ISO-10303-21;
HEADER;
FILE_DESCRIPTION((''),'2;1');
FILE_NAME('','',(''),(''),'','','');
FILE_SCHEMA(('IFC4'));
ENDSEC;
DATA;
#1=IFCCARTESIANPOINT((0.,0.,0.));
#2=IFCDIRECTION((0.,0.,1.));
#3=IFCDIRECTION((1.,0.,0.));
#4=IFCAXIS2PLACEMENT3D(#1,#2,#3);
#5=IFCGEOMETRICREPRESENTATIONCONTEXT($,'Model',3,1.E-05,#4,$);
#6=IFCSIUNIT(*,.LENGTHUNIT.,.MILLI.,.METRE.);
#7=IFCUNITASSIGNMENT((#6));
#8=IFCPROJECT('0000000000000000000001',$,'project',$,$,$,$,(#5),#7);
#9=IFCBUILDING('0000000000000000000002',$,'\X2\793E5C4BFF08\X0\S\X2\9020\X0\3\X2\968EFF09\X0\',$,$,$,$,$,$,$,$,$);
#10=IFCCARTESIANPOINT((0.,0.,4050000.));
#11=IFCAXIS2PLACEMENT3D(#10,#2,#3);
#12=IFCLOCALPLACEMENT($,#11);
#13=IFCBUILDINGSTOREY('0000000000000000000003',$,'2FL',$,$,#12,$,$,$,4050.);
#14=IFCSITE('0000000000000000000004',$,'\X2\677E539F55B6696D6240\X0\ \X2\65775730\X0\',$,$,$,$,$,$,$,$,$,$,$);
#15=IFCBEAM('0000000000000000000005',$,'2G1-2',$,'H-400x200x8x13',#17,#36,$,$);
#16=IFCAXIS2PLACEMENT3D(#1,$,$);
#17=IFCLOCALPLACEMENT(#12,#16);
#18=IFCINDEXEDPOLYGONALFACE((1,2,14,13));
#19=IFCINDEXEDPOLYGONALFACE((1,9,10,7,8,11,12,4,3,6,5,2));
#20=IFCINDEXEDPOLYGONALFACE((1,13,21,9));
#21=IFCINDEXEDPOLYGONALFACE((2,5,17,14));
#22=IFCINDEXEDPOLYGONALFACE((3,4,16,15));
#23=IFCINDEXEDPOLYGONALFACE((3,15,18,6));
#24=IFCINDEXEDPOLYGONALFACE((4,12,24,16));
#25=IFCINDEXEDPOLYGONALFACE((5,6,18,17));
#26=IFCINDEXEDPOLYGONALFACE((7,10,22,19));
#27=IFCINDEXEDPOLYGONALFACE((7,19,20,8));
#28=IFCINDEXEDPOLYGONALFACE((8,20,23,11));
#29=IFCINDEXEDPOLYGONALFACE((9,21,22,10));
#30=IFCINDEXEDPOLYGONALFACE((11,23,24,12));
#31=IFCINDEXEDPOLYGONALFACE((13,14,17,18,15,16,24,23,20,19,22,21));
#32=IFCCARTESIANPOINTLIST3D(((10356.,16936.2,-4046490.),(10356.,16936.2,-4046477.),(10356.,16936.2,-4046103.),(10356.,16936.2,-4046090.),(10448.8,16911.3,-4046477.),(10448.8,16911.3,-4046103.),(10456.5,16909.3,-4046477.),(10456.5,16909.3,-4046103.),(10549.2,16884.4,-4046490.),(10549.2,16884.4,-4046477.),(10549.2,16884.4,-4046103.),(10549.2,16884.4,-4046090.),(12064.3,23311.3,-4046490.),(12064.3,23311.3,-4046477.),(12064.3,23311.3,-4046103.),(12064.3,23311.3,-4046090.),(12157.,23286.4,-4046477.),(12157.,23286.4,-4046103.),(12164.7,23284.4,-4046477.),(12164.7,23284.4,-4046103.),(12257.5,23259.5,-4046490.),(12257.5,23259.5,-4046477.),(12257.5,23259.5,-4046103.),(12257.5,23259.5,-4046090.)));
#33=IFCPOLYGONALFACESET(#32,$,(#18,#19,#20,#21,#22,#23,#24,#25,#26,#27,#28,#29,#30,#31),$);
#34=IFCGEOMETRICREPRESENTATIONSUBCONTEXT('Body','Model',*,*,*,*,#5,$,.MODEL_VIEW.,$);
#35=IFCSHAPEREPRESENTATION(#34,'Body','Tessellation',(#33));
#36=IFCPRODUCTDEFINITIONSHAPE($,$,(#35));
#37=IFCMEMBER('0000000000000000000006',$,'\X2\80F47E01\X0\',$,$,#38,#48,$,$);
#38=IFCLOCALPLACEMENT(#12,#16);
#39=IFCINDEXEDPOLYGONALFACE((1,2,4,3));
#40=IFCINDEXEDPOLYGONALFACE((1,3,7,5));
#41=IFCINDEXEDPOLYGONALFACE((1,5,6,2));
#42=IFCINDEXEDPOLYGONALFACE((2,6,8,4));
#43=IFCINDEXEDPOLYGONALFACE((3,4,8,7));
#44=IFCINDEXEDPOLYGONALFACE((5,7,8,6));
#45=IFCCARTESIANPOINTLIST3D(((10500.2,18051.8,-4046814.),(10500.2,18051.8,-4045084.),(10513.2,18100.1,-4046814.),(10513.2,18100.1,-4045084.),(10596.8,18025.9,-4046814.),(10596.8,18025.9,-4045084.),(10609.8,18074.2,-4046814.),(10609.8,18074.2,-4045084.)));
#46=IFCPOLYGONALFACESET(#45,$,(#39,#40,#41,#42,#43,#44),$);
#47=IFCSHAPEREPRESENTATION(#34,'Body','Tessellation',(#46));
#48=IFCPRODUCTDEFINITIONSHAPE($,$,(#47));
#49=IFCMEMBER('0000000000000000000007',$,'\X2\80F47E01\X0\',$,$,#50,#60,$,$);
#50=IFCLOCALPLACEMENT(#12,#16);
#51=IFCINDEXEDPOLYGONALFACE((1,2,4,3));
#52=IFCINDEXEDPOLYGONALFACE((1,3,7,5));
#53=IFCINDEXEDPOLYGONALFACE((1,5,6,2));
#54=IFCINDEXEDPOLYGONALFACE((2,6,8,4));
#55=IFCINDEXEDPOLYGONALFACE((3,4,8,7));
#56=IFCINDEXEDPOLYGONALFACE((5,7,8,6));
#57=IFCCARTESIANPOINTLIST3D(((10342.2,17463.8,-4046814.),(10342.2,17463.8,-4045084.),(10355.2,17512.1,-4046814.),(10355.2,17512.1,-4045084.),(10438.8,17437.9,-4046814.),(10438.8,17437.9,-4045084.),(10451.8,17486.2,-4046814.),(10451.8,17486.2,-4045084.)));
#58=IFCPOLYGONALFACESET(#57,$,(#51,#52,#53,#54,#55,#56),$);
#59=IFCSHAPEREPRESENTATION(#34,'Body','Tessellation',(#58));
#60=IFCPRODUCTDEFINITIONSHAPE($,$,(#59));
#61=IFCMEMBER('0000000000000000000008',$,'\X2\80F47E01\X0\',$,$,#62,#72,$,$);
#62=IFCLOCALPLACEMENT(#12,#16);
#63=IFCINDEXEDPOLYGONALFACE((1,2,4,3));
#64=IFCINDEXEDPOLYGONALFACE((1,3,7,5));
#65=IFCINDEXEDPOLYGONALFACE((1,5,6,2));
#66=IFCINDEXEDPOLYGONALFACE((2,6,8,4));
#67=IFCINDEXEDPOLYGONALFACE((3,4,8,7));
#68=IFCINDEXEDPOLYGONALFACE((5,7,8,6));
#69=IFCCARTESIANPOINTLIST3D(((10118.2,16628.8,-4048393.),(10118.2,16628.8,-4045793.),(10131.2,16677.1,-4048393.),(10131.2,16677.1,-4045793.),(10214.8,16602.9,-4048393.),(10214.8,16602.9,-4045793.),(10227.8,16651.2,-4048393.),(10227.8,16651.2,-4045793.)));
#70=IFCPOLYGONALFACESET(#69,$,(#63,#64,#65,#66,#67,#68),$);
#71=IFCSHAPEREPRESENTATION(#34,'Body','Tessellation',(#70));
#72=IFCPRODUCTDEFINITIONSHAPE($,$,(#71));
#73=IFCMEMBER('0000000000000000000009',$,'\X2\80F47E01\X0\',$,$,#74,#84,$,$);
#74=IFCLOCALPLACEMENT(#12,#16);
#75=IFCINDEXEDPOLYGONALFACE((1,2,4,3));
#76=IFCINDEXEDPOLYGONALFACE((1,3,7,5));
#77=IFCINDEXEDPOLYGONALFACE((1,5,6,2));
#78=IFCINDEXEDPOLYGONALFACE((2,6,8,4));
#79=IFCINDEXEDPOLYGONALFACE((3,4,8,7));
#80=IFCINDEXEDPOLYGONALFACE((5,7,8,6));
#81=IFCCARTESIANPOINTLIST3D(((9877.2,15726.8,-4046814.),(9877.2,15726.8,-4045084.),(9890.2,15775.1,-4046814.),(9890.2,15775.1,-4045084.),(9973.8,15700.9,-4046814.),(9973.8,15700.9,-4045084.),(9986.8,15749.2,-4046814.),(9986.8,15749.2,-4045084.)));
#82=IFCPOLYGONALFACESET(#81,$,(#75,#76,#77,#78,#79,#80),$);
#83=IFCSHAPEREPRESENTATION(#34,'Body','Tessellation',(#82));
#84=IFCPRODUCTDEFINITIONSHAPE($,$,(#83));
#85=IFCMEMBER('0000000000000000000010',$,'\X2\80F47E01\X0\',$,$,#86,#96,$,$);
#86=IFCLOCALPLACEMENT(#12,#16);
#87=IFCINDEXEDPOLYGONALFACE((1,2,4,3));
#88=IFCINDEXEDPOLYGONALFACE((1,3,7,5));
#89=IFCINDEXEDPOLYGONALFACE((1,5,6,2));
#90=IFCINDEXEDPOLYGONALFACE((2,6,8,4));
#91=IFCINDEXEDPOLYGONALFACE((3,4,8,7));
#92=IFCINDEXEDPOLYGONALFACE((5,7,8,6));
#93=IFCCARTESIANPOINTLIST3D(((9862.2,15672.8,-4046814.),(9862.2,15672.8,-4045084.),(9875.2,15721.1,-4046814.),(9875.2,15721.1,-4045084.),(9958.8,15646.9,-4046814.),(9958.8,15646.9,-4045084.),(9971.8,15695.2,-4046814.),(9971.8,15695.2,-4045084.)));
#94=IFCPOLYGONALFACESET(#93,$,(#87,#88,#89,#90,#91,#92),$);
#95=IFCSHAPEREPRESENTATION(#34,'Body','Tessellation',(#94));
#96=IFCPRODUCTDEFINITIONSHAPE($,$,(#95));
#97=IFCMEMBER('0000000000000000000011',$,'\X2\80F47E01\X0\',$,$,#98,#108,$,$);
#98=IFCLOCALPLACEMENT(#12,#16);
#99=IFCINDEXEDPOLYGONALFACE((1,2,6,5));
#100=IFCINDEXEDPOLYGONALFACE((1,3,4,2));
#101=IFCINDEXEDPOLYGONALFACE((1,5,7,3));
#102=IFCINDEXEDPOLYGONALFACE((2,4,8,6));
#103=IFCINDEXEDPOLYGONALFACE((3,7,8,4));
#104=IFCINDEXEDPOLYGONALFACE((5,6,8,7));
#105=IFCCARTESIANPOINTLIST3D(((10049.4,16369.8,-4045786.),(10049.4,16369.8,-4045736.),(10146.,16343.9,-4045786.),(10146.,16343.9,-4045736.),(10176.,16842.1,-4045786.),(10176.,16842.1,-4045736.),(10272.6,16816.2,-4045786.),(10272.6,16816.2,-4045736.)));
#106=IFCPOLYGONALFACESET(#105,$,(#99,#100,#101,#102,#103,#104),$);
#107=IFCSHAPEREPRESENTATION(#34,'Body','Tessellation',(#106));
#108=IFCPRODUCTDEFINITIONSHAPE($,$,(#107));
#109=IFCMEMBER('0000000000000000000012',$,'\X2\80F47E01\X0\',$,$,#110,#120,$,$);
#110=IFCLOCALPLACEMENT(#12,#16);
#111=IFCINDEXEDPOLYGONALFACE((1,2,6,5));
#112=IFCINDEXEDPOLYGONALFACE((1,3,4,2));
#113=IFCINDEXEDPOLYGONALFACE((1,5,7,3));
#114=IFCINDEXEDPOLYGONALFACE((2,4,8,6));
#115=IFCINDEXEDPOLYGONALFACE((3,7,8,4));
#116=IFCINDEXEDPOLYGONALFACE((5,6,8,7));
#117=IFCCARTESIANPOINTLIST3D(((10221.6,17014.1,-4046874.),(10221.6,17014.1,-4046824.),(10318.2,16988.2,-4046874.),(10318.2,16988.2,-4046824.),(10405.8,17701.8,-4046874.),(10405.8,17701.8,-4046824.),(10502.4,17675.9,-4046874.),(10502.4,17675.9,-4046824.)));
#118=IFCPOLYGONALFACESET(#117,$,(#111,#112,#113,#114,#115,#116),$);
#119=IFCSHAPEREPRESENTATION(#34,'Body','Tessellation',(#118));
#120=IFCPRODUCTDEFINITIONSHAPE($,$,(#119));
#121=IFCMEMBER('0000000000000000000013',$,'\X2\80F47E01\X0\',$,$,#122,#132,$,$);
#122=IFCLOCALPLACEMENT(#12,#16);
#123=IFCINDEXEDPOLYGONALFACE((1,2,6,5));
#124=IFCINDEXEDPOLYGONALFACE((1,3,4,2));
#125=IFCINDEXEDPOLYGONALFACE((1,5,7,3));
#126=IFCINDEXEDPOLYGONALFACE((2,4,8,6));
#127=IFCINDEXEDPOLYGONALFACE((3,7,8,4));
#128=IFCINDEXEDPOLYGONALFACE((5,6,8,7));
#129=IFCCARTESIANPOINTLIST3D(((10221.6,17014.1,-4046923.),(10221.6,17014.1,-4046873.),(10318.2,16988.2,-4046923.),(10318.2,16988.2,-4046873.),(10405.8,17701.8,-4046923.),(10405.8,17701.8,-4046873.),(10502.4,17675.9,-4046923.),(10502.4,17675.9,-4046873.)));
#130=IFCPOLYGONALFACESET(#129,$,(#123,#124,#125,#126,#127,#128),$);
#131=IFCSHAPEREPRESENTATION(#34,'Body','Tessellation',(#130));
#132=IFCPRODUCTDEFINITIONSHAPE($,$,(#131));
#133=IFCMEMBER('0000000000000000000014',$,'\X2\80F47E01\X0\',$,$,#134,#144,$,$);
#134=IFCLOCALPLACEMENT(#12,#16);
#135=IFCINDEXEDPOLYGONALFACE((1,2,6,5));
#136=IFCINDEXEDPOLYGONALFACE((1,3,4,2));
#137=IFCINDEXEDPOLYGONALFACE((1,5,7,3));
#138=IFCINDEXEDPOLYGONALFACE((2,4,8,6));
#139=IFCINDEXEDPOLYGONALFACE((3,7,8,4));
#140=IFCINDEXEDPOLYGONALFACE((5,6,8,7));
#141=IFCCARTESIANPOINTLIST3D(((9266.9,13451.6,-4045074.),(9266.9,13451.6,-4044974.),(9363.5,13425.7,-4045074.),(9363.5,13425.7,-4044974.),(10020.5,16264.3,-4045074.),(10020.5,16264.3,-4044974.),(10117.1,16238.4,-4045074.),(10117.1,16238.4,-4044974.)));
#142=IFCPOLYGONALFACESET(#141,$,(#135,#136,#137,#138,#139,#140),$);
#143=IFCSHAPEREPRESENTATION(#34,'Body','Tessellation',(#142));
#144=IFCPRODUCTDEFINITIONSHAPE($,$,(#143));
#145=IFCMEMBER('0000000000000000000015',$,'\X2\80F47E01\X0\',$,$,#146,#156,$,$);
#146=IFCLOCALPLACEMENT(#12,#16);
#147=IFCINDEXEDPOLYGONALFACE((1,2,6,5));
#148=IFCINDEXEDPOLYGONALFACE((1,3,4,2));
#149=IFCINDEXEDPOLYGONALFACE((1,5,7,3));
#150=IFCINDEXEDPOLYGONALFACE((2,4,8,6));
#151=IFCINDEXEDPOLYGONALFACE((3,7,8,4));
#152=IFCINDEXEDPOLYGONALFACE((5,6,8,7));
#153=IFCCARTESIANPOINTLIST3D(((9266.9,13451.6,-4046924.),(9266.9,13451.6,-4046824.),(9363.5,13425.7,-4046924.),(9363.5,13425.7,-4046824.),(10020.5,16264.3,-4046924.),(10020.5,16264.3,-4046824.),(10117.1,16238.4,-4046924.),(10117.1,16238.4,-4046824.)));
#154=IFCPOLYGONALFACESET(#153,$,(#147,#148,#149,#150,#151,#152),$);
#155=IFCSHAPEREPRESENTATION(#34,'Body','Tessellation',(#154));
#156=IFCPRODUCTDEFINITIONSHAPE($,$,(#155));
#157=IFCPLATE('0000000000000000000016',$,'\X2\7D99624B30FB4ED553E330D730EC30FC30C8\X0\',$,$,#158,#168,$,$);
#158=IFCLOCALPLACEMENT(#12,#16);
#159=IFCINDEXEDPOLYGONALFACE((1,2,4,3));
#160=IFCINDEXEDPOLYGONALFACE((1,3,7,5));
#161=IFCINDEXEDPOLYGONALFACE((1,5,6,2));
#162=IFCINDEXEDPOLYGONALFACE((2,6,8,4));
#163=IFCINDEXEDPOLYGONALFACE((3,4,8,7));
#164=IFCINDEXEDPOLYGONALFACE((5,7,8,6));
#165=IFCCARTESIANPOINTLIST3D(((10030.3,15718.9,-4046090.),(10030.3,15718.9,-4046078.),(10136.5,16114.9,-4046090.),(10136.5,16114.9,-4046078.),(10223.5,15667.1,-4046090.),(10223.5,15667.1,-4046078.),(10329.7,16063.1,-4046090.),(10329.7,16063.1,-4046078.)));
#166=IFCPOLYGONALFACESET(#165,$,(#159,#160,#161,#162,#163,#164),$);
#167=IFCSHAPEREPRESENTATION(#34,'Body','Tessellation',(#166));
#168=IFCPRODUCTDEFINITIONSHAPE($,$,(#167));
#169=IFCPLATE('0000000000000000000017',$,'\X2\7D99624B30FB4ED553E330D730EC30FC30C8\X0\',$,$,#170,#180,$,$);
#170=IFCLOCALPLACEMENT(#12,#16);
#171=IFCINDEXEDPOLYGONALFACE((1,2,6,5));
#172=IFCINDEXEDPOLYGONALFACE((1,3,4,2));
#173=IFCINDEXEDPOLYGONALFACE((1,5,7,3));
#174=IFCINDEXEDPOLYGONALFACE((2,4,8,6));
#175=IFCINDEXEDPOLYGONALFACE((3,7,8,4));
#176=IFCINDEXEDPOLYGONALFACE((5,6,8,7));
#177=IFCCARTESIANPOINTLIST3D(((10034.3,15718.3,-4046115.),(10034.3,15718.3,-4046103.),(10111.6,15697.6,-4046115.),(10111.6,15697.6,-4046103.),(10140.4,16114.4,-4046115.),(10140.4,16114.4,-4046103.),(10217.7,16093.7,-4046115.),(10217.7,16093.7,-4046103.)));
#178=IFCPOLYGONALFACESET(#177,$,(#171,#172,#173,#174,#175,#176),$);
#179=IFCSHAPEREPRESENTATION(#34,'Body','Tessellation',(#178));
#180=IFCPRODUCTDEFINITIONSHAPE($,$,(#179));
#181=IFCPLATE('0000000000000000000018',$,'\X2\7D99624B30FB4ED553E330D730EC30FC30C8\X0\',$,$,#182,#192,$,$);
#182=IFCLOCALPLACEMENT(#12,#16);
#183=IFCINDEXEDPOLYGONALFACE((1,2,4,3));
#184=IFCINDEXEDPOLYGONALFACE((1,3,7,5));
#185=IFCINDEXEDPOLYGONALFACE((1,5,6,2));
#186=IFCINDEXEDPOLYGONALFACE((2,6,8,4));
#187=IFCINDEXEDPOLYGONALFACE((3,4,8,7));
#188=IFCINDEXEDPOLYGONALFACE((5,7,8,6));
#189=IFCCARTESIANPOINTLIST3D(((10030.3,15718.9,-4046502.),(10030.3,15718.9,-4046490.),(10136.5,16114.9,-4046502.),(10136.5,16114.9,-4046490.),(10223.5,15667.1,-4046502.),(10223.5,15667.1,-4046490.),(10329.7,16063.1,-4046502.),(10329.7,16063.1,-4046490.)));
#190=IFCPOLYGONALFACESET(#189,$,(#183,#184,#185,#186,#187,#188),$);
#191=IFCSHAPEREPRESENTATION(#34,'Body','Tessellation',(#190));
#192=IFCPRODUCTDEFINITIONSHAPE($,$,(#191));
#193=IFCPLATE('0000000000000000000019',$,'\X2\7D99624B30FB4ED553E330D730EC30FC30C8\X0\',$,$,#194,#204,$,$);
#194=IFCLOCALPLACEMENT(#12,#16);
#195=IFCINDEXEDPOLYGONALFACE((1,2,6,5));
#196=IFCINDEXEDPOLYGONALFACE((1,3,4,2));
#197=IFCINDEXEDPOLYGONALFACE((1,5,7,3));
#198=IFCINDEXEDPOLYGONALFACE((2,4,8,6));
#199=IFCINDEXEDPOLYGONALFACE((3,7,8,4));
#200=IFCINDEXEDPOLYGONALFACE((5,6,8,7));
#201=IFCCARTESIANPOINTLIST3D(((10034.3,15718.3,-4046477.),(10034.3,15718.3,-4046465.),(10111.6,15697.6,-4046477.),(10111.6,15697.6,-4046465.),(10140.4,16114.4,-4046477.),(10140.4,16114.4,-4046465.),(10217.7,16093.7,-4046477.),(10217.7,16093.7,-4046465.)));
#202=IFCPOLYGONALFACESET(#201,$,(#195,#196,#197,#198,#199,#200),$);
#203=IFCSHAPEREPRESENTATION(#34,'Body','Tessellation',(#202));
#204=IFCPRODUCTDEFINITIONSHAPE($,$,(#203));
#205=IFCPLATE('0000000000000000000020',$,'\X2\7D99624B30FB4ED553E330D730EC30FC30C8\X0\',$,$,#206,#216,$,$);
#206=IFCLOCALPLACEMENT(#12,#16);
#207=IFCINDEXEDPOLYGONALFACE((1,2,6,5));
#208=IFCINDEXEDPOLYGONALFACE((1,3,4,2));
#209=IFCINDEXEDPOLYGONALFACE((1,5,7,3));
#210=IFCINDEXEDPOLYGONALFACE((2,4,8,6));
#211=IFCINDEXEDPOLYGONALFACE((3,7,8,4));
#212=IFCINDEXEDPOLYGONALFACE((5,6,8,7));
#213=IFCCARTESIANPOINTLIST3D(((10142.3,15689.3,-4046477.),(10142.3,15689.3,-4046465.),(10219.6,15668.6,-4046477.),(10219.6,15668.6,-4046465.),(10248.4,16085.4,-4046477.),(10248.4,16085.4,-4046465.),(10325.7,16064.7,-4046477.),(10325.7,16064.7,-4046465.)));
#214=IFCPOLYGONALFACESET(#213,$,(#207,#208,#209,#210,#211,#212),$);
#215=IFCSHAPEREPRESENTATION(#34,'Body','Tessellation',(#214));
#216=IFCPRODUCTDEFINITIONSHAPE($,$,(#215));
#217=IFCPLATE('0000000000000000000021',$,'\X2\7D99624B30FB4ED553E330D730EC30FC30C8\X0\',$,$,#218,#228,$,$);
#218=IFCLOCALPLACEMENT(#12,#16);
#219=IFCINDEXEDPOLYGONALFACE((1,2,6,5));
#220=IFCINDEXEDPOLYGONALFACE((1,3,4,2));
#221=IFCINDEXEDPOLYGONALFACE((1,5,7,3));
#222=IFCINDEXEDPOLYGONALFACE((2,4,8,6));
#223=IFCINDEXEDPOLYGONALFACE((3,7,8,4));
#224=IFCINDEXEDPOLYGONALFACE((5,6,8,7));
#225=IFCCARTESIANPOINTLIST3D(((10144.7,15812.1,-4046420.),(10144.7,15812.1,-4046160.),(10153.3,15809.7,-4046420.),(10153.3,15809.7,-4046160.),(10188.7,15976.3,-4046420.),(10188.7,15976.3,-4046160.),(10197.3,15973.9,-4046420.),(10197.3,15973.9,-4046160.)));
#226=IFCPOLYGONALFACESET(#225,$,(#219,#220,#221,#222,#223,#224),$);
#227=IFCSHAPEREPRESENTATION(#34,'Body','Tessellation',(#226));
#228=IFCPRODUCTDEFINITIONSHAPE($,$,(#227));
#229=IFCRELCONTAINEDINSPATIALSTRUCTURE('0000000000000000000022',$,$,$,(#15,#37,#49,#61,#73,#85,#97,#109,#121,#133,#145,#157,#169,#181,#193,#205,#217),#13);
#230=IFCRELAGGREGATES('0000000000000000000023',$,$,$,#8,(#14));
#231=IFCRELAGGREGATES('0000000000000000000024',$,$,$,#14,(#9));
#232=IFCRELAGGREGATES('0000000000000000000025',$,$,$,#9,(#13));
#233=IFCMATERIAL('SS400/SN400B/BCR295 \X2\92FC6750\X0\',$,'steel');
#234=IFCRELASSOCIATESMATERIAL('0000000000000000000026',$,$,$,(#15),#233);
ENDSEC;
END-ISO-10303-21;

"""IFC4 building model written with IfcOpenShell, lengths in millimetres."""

from ifc_helpers import new_model, si_unit, frame, origin, origin_with_axes, place, context, subcontext, project, spatial, rectangle, i_section, extrude, material, element, save


model = new_model("IFC4")

# Units and contexts
model_context = context("Model", 3, precision=1e-05, world=origin_with_axes())
body_context = subcontext(model_context, "Body", "Model", "MODEL_VIEW")
ifc_project = project(units=[si_unit("LENGTHUNIT", "METRE", prefix="MILLI")], contexts=[model_context])

# Site, building, storey
site = spatial("IfcSite", under=ifc_project, Name="松原営業所 敷地")
building = spatial("IfcBuilding", under=site, Name="社屋（S造3階）")
storey_placement = place(None, frame((0.0, 0.0, 4050000.0), z_axis=(0.0, 0.0, 1.0), x_axis=(1.0, 0.0, 0.0)))
storey = spatial("IfcBuildingStorey", under=building, at=storey_placement, Name="2FL", Elevation=4050.0)

# Beam
ifc_material = material(Name="SS400/SN400B/BCR295 鋼材", Category="steel")
beam_placement = place(storey_placement, frame((10452.6, 16910.3, -4046090.0), z_axis=(0.258825, 0.965924, 0.0), x_axis=(-0.965924, 0.258825, 0.0)))
element("IfcBeam", 1, at=beam_placement, inside=storey, material=ifc_material, Name="2G1-2", ObjectType="H-400x200x8x13", context=body_context, shape_type="SweptSolid", body=[
    extrude(i_section(OverallWidth=200.0, OverallDepth=400.0, WebThickness=8.0, FlangeThickness=13.0), frame((0.0, -200.0, 0.0)), (0.0, 0.0, 1.0), 6600.0),
])

# Members
for number, where, z_axis, x_axis, name in (
    (2, (10561.5, 18087.1, -4045949.0), (-0.258819, -0.965926, 0.0), (0.965926, -0.258819, 0.0), "胴縁"),
    (3, (10403.5, 17499.1, -4045949.0), (-0.258819, -0.965926, 0.0), (0.965926, -0.258819, 0.0), "胴縁"),
):
    element("IfcMember", number, at=place(storey_placement, frame(where, z_axis=z_axis, x_axis=x_axis)), inside=storey, Name=name, context=body_context, shape_type="SweptSolid", body=[
        extrude(rectangle(XDim=100.0, YDim=1730.0), origin(), (0.0, 0.0, 1.0), 50.0),
    ])
member_1_placement = place(storey_placement, frame((10179.5, 16664.1, -4047093.0), z_axis=(-0.258819, -0.965926, 0.0), x_axis=(0.965926, -0.258819, 0.0)))
element("IfcMember", 4, at=member_1_placement, inside=storey, Name="胴縁", context=body_context, shape_type="SweptSolid", body=[
    extrude(rectangle(XDim=100.0, YDim=2600.0), origin(), (0.0, 0.0, 1.0), 50.0),
])
for number, where, z_axis, x_axis, name in (
    (5, (9938.5, 15762.1, -4045949.0), (-0.258819, -0.965926, 0.0), (0.965926, -0.258819, 0.0), "胴縁"),
    (6, (9923.5, 15708.1, -4045949.0), (-0.258819, -0.965926, 0.0), (0.965926, -0.258819, 0.0), "胴縁"),
):
    element("IfcMember", number, at=place(storey_placement, frame(where, z_axis=z_axis, x_axis=x_axis)), inside=storey, Name=name, context=body_context, shape_type="SweptSolid", body=[
        extrude(rectangle(XDim=100.0, YDim=1730.0), origin(), (0.0, 0.0, 1.0), 50.0),
    ])
member_2_placement = place(storey_placement, frame((10224.3, 16829.2, -4045761.0), z_axis=(-0.258819, -0.965926, 0.0), x_axis=(0.965926, -0.258819, 0.0)))
element("IfcMember", 7, at=member_2_placement, inside=storey, Name="胴縁", context=body_context, shape_type="SweptSolid", body=[
    extrude(rectangle(XDim=100.0, YDim=50.0), origin(), (0.0, 0.0, 1.0), 489.0),
])
for number, where, z_axis, x_axis, name in (
    (8, (10454.1, 17688.9, -4046849.0), (-0.258819, -0.965926, 0.0), (0.965926, -0.258819, 0.0), "胴縁"),
    (9, (10454.1, 17688.9, -4046898.0), (-0.258819, -0.965926, 0.0), (0.965926, -0.258819, 0.0), "胴縁"),
):
    element("IfcMember", number, at=place(storey_placement, frame(where, z_axis=z_axis, x_axis=x_axis)), inside=storey, Name=name, context=body_context, shape_type="SweptSolid", body=[
        extrude(rectangle(XDim=100.0, YDim=50.0), origin(), (0.0, 0.0, 1.0), 712.0),
    ])
for number, where, z_axis, x_axis, name in (
    (10, (10068.8, 16251.4, -4045024.0), (-0.258819, -0.965926, 0.0), (0.965926, -0.258819, 0.0), "胴縁"),
    (11, (10068.8, 16251.4, -4046874.0), (-0.258819, -0.965926, 0.0), (0.965926, -0.258819, 0.0), "胴縁"),
):
    element("IfcMember", number, at=place(storey_placement, frame(where, z_axis=z_axis, x_axis=x_axis)), inside=storey, Name=name, context=body_context, shape_type="SweptSolid", body=[
        extrude(rectangle(XDim=100.0, YDim=100.0), origin(), (0.0, 0.0, 1.0), 2912.0),
    ])

# Plates
plate_1_placement = place(storey_placement, frame((10126.9, 15693.0, -4046084.0), z_axis=(0.258819, 0.965926, 0.0), x_axis=(-0.965926, 0.258819, 0.0)))
element("IfcPlate", 12, at=plate_1_placement, inside=storey, Name="継手・仕口プレート", context=body_context, shape_type="SweptSolid", body=[
    extrude(rectangle(XDim=200.0, YDim=12.0), origin(), (0.0, 0.0, 1.0), 410.0),
])
plate_2_placement = place(storey_placement, frame((10072.9, 15708.0, -4046109.0), z_axis=(0.258819, 0.965926, 0.0), x_axis=(-0.965926, 0.258819, 0.0)))
element("IfcPlate", 13, at=plate_2_placement, inside=storey, Name="継手・仕口プレート", context=body_context, shape_type="SweptSolid", body=[
    extrude(rectangle(XDim=80.0, YDim=12.0), origin(), (0.0, 0.0, 1.0), 410.0),
])
plate_3_placement = place(storey_placement, frame((10126.9, 15693.0, -4046496.0), z_axis=(0.258819, 0.965926, 0.0), x_axis=(-0.965926, 0.258819, 0.0)))
element("IfcPlate", 14, at=plate_3_placement, inside=storey, Name="継手・仕口プレート", context=body_context, shape_type="SweptSolid", body=[
    extrude(rectangle(XDim=200.0, YDim=12.0), origin(), (0.0, 0.0, 1.0), 410.0),
])
for number, where, z_axis, x_axis, name in (
    (15, (10072.9, 15708.0, -4046471.0), (0.258819, 0.965926, 0.0), (-0.965926, 0.258819, 0.0), "継手・仕口プレート"),
    (16, (10180.9, 15679.0, -4046471.0), (0.258819, 0.965926, 0.0), (-0.965926, 0.258819, 0.0), "継手・仕口プレート"),
):
    element("IfcPlate", number, at=place(storey_placement, frame(where, z_axis=z_axis, x_axis=x_axis)), inside=storey, Name=name, context=body_context, shape_type="SweptSolid", body=[
        extrude(rectangle(XDim=80.0, YDim=12.0), origin(), (0.0, 0.0, 1.0), 410.0),
    ])
for number, where, z_axis, x_axis, name in (
    (17, (10149.0, 15810.9, -4046290.0), (0.258819, 0.965926, 0.0), (-0.965926, 0.258819, 0.0), "継手・仕口プレート"),
):
    element("IfcPlate", number, at=place(storey_placement, frame(where, z_axis=z_axis, x_axis=x_axis)), inside=storey, Name=name, context=body_context, shape_type="SweptSolid", body=[
        extrude(rectangle(XDim=9.0, YDim=260.0), origin(), (0.0, 0.0, 1.0), 170.0),
    ])

save(model, "model.ifc")
